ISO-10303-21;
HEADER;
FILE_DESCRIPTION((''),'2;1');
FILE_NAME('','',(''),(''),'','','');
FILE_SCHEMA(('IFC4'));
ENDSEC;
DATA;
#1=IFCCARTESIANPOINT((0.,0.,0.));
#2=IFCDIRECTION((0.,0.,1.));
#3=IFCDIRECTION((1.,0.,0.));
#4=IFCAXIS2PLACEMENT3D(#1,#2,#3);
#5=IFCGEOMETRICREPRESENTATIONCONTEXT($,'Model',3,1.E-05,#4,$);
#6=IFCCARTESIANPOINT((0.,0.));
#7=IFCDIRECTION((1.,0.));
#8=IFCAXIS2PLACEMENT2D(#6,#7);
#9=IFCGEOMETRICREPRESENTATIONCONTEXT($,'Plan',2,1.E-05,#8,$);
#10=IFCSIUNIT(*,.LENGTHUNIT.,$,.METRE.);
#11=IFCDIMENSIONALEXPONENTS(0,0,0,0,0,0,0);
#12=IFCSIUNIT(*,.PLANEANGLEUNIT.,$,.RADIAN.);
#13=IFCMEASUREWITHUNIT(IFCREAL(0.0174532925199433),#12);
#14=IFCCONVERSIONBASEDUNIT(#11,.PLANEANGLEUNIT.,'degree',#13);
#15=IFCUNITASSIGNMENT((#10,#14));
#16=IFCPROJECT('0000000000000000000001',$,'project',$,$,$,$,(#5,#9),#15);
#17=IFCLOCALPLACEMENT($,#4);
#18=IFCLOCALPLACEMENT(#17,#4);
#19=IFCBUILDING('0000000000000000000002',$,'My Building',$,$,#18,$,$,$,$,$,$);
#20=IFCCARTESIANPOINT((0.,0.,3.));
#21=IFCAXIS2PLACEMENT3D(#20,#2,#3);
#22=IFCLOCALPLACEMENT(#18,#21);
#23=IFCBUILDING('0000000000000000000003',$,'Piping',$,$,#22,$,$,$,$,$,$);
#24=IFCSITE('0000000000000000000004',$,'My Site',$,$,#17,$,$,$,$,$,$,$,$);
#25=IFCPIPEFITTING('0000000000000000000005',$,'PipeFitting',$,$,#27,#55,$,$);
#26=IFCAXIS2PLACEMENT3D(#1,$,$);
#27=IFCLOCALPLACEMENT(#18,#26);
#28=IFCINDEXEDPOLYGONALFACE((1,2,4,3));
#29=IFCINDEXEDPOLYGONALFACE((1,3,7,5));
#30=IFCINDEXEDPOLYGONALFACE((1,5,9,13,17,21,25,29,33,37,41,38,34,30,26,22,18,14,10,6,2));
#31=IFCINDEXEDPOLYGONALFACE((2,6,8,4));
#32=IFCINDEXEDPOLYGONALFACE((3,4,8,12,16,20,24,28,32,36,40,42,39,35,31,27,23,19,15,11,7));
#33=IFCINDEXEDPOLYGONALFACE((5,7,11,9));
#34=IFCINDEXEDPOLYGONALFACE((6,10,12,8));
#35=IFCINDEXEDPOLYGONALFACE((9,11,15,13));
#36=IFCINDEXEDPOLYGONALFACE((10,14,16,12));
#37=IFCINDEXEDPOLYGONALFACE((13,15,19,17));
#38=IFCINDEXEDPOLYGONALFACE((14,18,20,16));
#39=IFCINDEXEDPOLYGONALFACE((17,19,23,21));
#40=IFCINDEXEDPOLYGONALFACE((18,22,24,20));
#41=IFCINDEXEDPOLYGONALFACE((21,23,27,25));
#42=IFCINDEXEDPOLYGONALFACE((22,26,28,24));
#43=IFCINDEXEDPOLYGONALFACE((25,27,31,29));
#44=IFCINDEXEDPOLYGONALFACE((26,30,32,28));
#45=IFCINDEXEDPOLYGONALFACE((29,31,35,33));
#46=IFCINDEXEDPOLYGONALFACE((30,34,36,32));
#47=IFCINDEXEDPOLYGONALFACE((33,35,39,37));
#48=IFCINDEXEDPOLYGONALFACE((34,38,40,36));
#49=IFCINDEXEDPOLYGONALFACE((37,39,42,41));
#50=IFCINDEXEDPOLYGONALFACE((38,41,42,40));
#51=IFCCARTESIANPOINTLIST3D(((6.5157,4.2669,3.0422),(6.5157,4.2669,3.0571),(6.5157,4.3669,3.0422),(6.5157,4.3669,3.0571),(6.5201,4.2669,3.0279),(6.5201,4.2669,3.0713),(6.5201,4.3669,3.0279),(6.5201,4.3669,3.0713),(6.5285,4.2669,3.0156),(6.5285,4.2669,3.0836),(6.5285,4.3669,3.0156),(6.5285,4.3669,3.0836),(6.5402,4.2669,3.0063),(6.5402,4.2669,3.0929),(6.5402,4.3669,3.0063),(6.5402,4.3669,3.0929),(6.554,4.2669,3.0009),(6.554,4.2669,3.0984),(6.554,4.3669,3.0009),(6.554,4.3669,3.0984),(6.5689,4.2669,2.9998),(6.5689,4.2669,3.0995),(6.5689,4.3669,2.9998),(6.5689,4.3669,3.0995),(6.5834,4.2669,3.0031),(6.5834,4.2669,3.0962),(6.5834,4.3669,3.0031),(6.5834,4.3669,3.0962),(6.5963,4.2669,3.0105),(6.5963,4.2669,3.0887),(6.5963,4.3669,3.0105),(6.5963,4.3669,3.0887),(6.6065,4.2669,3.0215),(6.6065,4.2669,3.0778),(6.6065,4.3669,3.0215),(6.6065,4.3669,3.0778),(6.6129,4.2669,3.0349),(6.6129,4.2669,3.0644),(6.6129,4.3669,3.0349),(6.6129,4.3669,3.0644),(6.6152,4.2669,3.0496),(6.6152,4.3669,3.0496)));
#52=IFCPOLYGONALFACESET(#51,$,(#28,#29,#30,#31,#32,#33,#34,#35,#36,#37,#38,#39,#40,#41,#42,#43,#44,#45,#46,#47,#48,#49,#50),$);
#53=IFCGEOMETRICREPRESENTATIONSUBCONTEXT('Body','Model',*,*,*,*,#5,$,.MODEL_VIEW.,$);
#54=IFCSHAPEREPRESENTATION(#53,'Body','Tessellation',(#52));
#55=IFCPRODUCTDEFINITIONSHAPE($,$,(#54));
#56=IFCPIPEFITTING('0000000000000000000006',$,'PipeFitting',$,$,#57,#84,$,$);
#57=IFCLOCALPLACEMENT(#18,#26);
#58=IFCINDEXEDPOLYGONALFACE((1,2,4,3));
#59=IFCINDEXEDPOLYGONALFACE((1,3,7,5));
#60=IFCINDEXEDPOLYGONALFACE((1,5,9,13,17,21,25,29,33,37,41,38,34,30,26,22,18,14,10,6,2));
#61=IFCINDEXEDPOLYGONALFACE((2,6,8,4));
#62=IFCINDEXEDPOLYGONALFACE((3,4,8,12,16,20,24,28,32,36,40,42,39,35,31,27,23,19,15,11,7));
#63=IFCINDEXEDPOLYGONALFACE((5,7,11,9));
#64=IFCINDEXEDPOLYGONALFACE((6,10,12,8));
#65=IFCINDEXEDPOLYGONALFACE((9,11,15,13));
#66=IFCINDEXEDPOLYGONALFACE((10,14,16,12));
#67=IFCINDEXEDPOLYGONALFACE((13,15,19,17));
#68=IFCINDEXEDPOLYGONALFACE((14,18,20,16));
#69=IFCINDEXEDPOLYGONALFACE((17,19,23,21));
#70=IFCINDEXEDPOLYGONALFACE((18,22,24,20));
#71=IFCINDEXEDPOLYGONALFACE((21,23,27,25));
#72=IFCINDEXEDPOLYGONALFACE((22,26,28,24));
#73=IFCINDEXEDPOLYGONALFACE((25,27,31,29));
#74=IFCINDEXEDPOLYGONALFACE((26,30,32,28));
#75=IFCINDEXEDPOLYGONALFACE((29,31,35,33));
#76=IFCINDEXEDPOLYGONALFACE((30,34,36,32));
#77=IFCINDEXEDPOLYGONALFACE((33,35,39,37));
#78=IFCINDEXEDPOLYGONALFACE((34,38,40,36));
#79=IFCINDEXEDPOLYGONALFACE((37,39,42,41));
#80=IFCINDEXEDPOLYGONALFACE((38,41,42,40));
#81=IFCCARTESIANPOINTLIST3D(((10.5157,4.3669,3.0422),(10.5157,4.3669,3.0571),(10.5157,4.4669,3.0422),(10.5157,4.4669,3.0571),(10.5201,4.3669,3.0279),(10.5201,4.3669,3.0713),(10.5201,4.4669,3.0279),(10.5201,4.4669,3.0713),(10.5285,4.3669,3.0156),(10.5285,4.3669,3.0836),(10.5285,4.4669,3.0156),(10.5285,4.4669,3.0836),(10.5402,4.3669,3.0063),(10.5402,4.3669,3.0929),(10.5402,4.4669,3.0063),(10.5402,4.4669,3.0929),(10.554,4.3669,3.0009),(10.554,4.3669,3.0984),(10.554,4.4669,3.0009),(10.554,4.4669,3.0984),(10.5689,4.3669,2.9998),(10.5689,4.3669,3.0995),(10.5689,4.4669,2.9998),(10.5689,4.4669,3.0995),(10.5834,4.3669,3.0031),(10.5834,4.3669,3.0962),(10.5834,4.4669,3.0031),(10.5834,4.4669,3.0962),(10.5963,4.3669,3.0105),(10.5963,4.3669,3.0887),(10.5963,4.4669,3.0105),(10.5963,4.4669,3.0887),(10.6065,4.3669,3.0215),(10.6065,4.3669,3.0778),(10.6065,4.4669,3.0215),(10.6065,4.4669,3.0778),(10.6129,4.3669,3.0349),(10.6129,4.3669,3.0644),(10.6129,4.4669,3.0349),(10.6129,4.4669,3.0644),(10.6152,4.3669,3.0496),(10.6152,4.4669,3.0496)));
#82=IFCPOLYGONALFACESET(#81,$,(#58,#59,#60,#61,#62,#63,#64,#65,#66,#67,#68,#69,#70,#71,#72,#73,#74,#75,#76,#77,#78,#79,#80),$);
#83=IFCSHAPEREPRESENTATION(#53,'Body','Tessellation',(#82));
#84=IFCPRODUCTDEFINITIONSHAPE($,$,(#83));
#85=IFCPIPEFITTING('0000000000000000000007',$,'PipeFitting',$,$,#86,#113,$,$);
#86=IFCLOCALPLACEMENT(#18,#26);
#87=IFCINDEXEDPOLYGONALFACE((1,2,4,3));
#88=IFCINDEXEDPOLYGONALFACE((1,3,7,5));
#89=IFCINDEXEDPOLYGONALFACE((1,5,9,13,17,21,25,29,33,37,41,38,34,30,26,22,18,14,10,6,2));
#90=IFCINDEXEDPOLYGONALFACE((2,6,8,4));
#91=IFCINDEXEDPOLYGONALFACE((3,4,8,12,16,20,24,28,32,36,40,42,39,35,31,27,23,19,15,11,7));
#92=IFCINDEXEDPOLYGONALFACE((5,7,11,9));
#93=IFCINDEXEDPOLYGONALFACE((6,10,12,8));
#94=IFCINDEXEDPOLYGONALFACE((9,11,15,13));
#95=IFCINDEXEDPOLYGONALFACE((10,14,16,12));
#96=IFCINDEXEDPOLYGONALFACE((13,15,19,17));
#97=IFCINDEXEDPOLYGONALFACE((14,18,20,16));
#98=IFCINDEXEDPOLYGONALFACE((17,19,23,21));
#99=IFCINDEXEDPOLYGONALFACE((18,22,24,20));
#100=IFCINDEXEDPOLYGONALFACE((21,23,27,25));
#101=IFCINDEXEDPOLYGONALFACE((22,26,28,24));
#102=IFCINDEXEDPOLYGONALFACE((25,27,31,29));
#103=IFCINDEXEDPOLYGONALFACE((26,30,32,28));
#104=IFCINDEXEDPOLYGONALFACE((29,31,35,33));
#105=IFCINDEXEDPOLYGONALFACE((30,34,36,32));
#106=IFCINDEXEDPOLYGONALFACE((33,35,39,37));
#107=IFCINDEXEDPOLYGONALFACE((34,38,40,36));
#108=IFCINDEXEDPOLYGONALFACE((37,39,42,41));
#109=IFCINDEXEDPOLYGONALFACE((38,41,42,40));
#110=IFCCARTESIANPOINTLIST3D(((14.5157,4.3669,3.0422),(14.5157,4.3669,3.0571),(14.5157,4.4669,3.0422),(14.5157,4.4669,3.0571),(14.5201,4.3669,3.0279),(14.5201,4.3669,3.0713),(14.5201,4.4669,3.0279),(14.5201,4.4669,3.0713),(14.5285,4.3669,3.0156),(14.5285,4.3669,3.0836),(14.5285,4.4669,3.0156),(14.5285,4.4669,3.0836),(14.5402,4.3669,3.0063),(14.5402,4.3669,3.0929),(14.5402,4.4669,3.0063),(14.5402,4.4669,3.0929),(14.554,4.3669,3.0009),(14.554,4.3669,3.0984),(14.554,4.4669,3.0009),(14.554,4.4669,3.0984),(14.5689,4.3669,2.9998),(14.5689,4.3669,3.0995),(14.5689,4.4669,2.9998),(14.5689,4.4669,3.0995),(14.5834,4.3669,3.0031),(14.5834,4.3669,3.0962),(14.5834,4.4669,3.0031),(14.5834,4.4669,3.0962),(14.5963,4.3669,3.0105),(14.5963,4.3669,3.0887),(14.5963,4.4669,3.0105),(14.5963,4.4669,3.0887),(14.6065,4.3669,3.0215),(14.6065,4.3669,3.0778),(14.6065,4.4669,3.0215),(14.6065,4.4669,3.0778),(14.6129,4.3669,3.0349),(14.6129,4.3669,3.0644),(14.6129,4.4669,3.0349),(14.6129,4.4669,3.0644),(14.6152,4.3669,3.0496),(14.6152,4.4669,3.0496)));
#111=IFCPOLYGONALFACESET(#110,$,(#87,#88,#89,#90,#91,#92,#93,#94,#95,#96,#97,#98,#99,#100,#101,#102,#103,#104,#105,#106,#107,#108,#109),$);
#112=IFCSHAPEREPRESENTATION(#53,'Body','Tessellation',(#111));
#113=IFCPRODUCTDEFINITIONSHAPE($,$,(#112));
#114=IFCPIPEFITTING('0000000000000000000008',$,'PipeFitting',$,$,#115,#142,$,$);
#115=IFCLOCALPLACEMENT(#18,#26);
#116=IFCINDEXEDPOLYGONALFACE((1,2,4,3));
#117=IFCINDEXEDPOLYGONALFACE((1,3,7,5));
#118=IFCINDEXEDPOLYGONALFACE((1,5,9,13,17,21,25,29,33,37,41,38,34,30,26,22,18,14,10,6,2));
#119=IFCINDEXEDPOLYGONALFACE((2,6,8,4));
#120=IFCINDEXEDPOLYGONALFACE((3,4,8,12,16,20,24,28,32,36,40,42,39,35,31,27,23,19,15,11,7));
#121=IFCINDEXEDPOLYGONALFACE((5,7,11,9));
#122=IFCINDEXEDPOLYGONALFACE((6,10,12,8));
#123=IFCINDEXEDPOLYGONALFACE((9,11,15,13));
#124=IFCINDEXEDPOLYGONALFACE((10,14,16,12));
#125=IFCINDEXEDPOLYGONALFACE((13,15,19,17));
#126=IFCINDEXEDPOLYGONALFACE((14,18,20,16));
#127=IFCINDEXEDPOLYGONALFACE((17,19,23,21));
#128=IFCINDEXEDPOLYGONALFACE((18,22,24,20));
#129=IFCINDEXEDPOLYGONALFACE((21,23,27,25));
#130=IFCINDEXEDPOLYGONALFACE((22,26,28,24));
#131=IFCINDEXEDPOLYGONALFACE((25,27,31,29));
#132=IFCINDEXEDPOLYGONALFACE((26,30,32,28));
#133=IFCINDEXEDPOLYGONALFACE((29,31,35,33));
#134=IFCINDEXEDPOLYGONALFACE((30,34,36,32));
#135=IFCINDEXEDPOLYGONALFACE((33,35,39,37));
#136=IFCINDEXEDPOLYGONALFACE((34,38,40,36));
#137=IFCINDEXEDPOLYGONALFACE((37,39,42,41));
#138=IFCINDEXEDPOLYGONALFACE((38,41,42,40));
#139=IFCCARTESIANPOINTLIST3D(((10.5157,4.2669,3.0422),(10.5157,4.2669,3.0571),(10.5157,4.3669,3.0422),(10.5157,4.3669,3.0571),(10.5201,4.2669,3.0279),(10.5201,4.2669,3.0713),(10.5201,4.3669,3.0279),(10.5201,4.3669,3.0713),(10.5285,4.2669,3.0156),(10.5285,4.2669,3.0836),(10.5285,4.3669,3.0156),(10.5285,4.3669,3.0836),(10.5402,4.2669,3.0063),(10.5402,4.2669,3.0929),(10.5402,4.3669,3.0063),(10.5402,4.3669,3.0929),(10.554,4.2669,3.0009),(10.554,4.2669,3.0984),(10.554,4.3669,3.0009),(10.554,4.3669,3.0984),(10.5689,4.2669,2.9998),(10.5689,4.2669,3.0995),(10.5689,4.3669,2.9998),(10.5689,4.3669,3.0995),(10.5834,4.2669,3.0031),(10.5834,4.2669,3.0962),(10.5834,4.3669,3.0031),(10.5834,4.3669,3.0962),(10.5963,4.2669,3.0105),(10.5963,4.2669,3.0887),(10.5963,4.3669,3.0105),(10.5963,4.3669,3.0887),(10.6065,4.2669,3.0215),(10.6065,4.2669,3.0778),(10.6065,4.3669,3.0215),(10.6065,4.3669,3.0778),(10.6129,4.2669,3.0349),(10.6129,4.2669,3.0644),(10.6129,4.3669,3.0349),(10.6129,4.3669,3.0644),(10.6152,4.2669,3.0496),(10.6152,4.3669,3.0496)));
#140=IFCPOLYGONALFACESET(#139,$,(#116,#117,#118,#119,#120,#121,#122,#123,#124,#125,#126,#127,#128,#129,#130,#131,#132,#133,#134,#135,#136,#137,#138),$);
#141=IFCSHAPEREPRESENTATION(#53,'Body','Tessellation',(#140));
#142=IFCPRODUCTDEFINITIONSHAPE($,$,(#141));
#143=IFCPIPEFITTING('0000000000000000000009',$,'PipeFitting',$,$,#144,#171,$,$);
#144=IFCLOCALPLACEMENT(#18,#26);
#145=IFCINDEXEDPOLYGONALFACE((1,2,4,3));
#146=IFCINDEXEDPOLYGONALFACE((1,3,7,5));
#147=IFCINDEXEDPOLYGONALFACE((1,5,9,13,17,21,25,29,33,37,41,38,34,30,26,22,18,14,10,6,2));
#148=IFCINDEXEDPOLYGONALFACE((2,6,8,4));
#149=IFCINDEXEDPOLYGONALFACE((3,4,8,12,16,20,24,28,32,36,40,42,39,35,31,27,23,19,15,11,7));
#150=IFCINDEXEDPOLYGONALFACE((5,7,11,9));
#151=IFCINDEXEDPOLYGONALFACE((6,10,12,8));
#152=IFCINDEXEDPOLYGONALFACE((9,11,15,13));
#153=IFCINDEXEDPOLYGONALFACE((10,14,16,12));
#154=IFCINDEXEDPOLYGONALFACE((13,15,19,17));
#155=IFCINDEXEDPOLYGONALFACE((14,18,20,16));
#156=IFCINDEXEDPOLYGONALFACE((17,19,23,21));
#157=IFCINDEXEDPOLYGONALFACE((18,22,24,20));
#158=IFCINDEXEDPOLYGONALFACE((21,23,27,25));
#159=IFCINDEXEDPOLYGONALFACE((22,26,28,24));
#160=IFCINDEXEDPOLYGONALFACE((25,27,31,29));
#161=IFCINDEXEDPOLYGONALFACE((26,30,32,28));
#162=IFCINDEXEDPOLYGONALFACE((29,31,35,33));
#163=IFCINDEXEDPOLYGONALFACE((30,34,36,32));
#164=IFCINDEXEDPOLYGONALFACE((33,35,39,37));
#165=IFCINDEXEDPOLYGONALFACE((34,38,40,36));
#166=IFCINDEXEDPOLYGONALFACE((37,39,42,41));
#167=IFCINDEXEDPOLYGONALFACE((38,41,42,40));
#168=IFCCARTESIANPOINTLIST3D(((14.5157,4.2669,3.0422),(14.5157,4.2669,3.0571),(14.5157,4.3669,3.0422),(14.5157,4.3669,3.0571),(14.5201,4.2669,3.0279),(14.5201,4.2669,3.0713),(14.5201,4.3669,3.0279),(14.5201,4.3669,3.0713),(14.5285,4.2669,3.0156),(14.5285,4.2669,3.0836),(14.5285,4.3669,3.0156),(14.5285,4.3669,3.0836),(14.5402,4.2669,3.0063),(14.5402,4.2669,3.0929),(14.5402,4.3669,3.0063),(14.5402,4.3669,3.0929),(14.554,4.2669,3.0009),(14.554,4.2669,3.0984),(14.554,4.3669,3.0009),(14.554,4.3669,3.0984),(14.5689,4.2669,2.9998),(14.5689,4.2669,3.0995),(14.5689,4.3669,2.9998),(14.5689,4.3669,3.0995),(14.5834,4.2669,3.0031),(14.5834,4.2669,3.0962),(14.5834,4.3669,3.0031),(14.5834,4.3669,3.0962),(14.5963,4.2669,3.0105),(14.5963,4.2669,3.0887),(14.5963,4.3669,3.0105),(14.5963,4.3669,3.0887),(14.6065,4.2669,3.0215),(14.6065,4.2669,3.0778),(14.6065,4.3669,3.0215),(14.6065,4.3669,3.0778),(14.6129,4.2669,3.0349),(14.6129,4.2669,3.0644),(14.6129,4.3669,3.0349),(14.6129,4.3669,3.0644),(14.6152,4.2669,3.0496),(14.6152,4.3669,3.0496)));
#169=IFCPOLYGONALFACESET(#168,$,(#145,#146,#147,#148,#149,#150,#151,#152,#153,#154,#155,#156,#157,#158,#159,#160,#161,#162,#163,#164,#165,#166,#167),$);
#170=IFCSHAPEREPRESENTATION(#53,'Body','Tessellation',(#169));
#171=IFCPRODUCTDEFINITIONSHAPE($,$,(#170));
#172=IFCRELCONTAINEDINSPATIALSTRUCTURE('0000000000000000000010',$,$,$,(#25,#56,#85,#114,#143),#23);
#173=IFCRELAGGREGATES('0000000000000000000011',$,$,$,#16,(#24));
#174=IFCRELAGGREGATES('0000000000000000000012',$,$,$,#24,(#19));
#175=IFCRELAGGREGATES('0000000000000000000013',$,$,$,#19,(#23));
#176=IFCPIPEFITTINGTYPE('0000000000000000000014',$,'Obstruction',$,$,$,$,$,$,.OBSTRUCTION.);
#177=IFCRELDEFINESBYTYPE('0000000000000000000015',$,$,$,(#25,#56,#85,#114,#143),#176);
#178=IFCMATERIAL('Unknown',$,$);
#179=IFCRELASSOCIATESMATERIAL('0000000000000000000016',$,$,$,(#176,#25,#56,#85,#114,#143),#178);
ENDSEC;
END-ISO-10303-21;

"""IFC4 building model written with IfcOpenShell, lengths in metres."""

from ifc_helpers import new_model, entity, si_unit, converted_unit, frame, origin_with_axes, origin_2d_with_axis, place, context, subcontext, project, spatial, circle, extrude, material, material_profile, profile_set, profile_usage, type_object, element, save


model = new_model("IFC4")

# Units and contexts
model_context = context("Model", 3, precision=1e-05, world=origin_with_axes())
plan_context = context("Plan", 2, precision=1e-05, world=origin_2d_with_axis())
body_context = subcontext(model_context, "Body", "Model", "MODEL_VIEW")
ifc_project = project(units=[si_unit("LENGTHUNIT", "METRE"), converted_unit("PLANEANGLEUNIT", "degree", entity("IfcReal", 0.0174532925199433), si_unit("PLANEANGLEUNIT", "RADIAN"), dimensions=[0, 0, 0, 0, 0, 0, 0])], contexts=[model_context, plan_context])

# Site, buildings
site_placement = place(None, origin_with_axes())
site = spatial("IfcSite", under=ifc_project, at=site_placement, Name="My Site")
building_1_placement = place(site_placement, origin_with_axes())
building_1 = spatial("IfcBuilding", under=site, at=building_1_placement, Name="My Building")
building_2_placement = place(building_1_placement, frame((0.0, 0.0, 3.0), z_axis=(0.0, 0.0, 1.0), x_axis=(1.0, 0.0, 0.0)))
building_2 = spatial("IfcBuilding", under=building_1, at=building_2_placement, Name="Piping")

# Shared definitions
ifc_material = material(Name="Unknown")

# Pipe fittings
ifc_material_profile_1 = material_profile(ifc_material, circle(Radius=0.05))
ifc_profile_set_1 = profile_set([ifc_material_profile_1])
pipe_fitting_type_1 = type_object("IfcPipeFittingType", Name="Obstruction", PredefinedType="OBSTRUCTION", material=ifc_profile_set_1)
ifc_profile_usage_1 = profile_usage(ifc_profile_set_1, cardinal=5)
pipe_fitting_1_placement = place(building_2_placement, frame((6.5652, 4.2669, 0.0496), z_axis=(0.0, 1.0, 0.0), x_axis=(1.0, 0.0, 0.0)))
element("IfcPipeFitting", 1, at=pipe_fitting_1_placement, inside=building_2, type_object=pipe_fitting_type_1, material=ifc_profile_usage_1, Name="PipeFitting", context=body_context, shape_type="SweptSolid", body=[
    extrude(circle(Radius=0.05), origin_with_axes(), (0.0, 0.0, 1.0), 0.1),
])
ifc_profile_usage_2 = profile_usage(ifc_profile_set_1, cardinal=5)
pipe_fitting_2_placement = place(building_2_placement, frame((10.5652, 4.3669, 0.0496), z_axis=(0.0, 1.0, 0.0), x_axis=(1.0, 0.0, 0.0)))
element("IfcPipeFitting", 2, at=pipe_fitting_2_placement, inside=building_2, type_object=pipe_fitting_type_1, material=ifc_profile_usage_2, Name="PipeFitting", context=body_context, shape_type="SweptSolid", body=[
    extrude(circle(Radius=0.05), origin_with_axes(), (0.0, 0.0, 1.0), 0.1),
])
ifc_profile_usage_3 = profile_usage(ifc_profile_set_1, cardinal=5)
pipe_fitting_3_placement = place(building_2_placement, frame((14.5652, 4.3669, 0.0496), z_axis=(0.0, 1.0, 0.0), x_axis=(1.0, 0.0, 0.0)))
element("IfcPipeFitting", 3, at=pipe_fitting_3_placement, inside=building_2, type_object=pipe_fitting_type_1, material=ifc_profile_usage_3, Name="PipeFitting", context=body_context, shape_type="SweptSolid", body=[
    extrude(circle(Radius=0.05), origin_with_axes(), (0.0, 0.0, 1.0), 0.1),
])
ifc_profile_usage_4 = profile_usage(ifc_profile_set_1, cardinal=5)
pipe_fitting_4_placement = place(building_2_placement, frame((10.5652, 4.2669, 0.0496), z_axis=(0.0, 1.0, 0.000001), x_axis=(1.0, 0.0, 0.0)))
element("IfcPipeFitting", 4, at=pipe_fitting_4_placement, inside=building_2, type_object=pipe_fitting_type_1, material=ifc_profile_usage_4, Name="PipeFitting", context=body_context, shape_type="SweptSolid", body=[
    extrude(circle(Radius=0.05), origin_with_axes(), (0.0, 0.0, 1.0), 0.1),
])
ifc_profile_usage_5 = profile_usage(ifc_profile_set_1, cardinal=5)
pipe_fitting_5_placement = place(building_2_placement, frame((14.5652, 4.2669, 0.0496), z_axis=(0.0, 1.0, 0.000001), x_axis=(1.0, 0.0, 0.0)))
element("IfcPipeFitting", 5, at=pipe_fitting_5_placement, inside=building_2, type_object=pipe_fitting_type_1, material=ifc_profile_usage_5, Name="PipeFitting", context=body_context, shape_type="SweptSolid", body=[
    extrude(circle(Radius=0.05), origin_with_axes(), (0.0, 0.0, 1.0), 0.1),
])

save(model, "model.ifc")
